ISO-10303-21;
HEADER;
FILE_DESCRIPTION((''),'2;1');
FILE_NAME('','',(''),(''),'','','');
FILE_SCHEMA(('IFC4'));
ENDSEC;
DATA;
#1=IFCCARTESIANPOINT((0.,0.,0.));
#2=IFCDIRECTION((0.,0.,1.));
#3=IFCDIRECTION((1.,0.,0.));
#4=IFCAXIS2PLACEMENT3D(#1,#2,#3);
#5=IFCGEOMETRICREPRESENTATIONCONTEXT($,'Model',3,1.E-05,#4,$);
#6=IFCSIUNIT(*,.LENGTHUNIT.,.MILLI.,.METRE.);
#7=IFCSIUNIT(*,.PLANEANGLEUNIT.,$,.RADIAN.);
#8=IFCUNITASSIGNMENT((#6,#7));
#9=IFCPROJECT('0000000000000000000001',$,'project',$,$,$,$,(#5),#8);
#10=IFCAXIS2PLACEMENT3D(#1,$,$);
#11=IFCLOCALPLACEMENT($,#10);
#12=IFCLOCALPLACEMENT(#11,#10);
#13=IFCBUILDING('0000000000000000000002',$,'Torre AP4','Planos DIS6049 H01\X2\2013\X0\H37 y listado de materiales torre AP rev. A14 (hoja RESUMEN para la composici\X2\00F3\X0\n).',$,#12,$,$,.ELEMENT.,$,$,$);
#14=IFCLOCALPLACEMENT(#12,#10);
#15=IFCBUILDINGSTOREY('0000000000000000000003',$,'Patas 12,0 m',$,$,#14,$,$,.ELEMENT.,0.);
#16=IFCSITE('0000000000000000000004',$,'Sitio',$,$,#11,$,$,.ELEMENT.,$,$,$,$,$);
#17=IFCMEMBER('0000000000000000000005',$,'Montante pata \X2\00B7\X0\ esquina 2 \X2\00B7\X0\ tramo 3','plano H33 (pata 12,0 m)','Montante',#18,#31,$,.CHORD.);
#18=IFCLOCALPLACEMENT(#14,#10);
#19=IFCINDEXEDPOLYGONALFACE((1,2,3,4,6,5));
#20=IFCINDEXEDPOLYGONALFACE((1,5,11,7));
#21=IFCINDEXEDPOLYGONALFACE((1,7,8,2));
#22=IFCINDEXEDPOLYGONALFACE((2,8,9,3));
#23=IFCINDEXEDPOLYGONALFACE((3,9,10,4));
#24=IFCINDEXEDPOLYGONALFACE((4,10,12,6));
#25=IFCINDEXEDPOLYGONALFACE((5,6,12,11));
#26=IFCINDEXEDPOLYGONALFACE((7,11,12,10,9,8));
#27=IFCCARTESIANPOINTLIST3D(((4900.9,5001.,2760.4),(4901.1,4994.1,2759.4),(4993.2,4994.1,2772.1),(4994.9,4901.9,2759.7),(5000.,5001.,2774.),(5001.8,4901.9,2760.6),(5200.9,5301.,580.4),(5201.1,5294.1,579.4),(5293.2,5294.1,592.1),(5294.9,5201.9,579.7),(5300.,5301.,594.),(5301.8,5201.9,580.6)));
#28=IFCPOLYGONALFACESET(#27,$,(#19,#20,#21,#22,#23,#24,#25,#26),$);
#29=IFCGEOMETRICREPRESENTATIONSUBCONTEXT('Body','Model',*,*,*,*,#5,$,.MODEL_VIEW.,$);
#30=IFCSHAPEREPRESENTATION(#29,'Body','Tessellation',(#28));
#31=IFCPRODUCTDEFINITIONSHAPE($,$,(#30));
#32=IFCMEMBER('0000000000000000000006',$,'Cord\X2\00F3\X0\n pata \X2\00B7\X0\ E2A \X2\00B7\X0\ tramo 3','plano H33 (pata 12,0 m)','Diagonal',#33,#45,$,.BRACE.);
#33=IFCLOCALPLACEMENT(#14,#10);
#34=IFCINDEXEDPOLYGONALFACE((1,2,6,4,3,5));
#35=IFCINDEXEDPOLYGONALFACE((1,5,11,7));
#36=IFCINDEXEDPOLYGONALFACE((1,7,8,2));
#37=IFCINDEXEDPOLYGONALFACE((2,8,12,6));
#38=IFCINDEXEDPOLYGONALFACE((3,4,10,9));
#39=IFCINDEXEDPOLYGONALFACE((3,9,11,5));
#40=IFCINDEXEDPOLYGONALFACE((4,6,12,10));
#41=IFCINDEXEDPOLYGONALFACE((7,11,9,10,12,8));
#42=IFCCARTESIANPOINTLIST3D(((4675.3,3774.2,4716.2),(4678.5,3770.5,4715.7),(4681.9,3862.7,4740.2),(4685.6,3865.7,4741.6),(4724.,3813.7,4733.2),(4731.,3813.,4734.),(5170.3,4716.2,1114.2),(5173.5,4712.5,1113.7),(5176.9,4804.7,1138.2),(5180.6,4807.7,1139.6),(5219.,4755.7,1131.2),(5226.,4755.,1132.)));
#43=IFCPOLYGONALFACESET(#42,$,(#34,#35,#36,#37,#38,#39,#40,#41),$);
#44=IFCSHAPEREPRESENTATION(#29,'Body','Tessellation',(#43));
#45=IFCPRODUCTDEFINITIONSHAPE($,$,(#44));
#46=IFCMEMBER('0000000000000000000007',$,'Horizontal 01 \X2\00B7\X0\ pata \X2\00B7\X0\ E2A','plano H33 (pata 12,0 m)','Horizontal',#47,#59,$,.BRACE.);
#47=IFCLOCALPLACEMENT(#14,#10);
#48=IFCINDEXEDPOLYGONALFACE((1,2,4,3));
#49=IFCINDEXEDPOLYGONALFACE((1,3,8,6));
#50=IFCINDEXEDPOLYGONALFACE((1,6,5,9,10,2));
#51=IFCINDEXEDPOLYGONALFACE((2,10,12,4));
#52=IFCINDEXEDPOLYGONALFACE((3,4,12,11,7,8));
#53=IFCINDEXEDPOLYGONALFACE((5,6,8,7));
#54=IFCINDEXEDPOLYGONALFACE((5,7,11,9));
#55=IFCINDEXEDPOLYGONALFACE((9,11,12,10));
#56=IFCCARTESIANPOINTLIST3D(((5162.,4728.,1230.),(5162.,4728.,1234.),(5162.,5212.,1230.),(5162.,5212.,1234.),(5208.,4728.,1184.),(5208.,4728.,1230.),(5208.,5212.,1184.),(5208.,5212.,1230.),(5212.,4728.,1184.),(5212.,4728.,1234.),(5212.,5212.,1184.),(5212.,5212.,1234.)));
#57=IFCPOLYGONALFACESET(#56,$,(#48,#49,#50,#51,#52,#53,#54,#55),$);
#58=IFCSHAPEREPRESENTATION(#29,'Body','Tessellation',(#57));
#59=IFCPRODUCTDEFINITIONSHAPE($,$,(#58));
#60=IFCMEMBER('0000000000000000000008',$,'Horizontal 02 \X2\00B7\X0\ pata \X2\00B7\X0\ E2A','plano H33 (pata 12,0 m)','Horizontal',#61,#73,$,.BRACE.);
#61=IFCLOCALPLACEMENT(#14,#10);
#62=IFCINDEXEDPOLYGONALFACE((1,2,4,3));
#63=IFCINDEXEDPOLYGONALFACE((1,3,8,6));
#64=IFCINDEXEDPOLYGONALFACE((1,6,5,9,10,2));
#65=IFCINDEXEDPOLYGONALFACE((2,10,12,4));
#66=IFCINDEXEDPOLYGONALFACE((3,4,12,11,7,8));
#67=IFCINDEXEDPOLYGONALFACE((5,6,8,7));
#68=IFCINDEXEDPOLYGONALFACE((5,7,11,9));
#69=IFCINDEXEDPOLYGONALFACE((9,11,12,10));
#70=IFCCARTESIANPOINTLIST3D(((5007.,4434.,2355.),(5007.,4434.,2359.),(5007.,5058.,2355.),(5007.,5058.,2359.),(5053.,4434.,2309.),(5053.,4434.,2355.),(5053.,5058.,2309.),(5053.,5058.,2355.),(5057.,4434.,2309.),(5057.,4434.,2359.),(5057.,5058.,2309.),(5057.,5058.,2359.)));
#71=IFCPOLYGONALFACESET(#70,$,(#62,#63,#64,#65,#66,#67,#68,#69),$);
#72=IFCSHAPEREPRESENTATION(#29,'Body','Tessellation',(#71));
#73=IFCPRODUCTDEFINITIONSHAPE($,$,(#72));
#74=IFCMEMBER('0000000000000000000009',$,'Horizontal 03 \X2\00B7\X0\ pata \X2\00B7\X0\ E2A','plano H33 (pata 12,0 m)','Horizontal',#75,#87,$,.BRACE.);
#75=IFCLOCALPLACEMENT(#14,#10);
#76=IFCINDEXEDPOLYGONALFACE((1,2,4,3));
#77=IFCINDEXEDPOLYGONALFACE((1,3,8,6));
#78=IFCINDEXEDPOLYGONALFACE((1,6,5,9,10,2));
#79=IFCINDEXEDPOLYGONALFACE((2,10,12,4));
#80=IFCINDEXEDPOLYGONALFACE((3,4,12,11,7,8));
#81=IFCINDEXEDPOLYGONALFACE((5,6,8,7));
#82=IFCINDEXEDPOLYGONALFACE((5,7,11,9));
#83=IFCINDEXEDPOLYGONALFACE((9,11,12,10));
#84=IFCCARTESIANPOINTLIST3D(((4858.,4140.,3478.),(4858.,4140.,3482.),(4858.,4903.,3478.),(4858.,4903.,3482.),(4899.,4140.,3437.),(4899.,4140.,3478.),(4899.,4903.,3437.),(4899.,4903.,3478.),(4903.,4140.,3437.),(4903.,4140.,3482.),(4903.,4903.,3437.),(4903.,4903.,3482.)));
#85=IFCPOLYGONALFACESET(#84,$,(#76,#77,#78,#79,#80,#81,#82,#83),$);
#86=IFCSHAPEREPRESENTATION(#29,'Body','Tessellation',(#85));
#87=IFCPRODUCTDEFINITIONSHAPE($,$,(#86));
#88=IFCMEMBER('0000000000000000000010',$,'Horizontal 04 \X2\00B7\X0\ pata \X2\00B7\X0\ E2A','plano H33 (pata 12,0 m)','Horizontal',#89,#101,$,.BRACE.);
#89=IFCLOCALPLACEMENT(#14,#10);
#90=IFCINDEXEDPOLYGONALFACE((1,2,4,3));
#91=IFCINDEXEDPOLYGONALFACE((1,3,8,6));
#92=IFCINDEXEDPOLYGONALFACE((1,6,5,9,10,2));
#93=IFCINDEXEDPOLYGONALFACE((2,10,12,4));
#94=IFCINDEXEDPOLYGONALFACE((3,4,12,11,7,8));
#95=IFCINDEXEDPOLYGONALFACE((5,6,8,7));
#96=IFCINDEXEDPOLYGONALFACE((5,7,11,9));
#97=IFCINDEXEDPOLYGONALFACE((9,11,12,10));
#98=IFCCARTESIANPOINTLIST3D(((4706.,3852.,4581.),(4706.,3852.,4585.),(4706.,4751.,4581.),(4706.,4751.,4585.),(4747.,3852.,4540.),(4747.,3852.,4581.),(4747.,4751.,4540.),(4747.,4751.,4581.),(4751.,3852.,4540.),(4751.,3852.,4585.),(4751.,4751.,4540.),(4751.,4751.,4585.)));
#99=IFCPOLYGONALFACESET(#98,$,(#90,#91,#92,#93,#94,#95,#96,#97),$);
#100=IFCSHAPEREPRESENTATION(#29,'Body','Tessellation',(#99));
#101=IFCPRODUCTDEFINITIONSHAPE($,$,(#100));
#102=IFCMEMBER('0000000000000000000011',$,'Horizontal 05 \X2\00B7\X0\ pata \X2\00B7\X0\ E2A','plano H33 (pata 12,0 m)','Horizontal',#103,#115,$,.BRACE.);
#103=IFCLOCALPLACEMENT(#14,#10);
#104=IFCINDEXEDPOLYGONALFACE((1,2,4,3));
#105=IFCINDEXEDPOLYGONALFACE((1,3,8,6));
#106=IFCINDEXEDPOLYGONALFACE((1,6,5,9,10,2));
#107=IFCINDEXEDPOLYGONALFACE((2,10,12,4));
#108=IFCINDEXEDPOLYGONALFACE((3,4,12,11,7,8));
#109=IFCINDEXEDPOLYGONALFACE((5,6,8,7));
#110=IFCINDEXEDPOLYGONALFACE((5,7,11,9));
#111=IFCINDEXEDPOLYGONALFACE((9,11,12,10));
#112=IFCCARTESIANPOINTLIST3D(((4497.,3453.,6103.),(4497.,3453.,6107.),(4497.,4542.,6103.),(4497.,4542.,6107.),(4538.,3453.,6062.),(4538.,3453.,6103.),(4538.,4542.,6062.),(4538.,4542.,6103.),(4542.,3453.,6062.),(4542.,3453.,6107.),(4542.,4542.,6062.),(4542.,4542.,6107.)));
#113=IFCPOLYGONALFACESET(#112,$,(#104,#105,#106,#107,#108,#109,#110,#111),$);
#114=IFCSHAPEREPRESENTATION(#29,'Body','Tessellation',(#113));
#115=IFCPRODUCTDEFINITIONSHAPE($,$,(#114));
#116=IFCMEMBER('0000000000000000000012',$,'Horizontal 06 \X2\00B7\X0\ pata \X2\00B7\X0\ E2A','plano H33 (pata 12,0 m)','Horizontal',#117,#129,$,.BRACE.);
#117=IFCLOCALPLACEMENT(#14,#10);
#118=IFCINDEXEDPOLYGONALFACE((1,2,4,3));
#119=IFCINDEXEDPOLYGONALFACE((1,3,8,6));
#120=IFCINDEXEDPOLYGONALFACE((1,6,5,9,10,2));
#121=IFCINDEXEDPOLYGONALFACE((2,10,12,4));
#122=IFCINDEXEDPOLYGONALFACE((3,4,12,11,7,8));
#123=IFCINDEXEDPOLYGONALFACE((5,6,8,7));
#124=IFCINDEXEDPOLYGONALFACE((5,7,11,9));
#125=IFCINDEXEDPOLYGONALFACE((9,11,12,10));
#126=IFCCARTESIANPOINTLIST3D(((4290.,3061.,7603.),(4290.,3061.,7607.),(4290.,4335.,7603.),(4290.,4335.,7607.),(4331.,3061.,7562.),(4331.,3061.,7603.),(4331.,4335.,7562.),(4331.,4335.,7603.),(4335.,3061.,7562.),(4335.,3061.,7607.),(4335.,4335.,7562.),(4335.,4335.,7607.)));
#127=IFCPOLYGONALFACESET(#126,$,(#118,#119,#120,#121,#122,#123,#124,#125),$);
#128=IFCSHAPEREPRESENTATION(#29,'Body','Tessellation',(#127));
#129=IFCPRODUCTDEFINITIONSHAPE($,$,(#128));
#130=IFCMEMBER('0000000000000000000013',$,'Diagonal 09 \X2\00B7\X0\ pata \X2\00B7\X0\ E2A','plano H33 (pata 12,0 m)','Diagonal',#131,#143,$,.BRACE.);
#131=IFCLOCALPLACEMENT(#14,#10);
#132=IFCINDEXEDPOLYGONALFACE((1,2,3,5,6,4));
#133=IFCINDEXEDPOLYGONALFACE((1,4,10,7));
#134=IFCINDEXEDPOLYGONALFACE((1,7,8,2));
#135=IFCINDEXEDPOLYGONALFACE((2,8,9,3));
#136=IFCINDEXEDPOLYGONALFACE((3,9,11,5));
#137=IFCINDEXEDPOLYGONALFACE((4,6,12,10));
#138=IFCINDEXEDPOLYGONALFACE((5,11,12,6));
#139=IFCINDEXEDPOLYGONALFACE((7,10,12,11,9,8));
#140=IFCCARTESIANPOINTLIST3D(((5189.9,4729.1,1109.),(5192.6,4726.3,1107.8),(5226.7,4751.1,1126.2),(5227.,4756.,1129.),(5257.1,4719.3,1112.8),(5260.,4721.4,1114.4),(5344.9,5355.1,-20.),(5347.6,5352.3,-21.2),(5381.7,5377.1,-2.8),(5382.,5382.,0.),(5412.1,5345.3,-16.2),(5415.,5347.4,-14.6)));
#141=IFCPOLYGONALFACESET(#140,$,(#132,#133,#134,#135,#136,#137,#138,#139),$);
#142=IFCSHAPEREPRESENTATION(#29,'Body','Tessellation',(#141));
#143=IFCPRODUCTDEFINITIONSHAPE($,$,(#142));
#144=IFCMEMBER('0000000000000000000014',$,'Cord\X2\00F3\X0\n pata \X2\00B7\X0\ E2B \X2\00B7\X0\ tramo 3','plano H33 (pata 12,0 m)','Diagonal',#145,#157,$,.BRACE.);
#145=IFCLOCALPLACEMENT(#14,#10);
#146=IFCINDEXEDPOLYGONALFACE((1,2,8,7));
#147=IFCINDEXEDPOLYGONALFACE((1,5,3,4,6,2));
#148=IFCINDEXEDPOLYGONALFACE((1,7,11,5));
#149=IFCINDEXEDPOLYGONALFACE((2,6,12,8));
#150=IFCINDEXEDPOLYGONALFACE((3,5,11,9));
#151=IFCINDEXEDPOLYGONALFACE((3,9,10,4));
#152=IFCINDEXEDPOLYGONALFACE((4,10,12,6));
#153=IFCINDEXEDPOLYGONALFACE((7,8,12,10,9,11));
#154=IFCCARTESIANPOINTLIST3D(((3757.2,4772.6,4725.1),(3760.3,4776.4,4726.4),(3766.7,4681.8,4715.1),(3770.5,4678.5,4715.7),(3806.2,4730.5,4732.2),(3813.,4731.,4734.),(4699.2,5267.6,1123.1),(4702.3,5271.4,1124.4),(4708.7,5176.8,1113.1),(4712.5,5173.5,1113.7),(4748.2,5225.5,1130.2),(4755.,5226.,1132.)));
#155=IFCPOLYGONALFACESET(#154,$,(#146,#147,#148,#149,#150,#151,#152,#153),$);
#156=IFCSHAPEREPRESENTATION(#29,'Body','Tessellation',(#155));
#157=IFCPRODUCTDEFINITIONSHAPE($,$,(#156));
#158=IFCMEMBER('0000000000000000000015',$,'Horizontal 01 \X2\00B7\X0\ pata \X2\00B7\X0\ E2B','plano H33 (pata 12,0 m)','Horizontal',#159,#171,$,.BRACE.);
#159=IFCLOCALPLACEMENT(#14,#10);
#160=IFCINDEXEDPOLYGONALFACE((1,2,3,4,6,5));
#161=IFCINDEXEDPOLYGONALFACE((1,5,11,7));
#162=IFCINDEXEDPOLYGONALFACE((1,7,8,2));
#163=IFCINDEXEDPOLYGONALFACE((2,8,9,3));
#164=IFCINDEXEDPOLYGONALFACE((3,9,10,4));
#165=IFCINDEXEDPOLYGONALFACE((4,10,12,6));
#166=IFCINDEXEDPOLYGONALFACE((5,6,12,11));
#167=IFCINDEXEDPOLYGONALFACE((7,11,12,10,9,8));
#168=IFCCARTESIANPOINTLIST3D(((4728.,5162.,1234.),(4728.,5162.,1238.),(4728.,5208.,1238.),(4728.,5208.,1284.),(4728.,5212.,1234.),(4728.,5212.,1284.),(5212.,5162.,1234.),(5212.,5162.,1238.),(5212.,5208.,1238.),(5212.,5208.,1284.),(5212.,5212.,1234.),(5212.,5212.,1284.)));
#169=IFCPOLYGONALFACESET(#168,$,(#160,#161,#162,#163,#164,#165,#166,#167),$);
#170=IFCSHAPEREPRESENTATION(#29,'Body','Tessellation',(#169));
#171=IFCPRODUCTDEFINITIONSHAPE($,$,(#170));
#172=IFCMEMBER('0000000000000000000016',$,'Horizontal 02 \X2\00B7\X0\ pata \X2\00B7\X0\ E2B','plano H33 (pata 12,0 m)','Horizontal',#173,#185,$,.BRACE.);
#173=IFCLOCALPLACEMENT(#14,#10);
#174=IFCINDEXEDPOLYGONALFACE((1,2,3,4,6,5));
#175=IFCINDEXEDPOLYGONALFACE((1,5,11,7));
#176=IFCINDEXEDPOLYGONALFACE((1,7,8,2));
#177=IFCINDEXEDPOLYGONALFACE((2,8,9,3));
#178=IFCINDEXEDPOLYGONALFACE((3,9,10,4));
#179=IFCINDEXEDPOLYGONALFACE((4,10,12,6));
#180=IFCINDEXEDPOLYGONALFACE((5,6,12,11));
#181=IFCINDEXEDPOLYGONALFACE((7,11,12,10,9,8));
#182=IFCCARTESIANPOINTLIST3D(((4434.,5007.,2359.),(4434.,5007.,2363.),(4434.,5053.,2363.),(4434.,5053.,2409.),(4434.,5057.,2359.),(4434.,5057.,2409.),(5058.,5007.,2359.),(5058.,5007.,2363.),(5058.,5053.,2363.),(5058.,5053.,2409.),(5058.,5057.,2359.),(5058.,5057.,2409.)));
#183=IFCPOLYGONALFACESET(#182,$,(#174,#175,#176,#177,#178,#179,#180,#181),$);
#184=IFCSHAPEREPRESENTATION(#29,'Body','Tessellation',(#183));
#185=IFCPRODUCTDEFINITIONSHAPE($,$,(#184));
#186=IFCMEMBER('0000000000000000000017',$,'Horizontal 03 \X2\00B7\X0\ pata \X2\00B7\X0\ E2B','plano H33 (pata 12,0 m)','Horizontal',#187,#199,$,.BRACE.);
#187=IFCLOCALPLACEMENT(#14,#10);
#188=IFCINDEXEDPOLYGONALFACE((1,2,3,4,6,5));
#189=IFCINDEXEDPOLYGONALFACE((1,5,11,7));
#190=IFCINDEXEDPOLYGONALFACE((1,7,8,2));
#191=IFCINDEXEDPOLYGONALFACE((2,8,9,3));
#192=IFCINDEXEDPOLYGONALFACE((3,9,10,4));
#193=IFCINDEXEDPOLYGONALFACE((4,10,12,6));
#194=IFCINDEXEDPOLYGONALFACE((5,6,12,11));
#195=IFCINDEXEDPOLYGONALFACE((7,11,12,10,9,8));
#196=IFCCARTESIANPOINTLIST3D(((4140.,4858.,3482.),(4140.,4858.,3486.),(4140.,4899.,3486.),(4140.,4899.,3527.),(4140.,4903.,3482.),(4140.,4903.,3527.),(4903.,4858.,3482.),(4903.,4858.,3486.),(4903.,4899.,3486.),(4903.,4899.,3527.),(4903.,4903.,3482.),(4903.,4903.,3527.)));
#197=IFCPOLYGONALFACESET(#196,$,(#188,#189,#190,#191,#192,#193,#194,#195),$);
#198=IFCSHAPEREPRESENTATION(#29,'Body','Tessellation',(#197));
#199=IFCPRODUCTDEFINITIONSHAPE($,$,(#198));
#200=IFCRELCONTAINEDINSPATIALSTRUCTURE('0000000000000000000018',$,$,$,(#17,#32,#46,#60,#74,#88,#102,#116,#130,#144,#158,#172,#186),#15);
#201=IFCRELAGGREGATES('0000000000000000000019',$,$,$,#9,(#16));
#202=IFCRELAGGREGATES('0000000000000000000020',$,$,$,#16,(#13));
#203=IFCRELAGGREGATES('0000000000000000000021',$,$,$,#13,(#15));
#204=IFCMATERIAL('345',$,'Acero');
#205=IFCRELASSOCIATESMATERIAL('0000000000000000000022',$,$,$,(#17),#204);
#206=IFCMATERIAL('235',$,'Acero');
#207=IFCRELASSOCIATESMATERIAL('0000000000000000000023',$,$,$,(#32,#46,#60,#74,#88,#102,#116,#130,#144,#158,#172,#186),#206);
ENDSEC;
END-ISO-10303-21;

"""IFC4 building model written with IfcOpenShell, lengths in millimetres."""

from ifc_helpers import new_model, si_unit, frame, frame_2d, origin, origin_with_axes, place, context, subcontext, project, spatial, l_section, extrude, material, element, save


model = new_model("IFC4")

# Units and contexts
model_context = context("Model", 3, precision=1e-05, world=origin_with_axes())
body_context = subcontext(model_context, "Body", "Model", "MODEL_VIEW")
ifc_project = project(units=[si_unit("LENGTHUNIT", "METRE", prefix="MILLI"), si_unit("PLANEANGLEUNIT", "RADIAN")], contexts=[model_context])

# Site, building, storey
site_placement = place(None, origin())
site = spatial("IfcSite", under=ifc_project, at=site_placement, Name="Sitio", CompositionType="ELEMENT")
building_placement = place(site_placement, origin())
building = spatial("IfcBuilding", under=site, at=building_placement, Name="Torre AP4", Description="Planos DIS6049 H01–H37 y listado de materiales torre AP rev. A14 (hoja RESUMEN para la composición).", CompositionType="ELEMENT")
storey_placement = place(building_placement, origin())
storey = spatial("IfcBuildingStorey", under=building, at=storey_placement, Name="Patas 12,0 m", CompositionType="ELEMENT", Elevation=0.0)

# Members
ifc_material_1 = material(Name="345", Category="Acero")
member_1_placement = place(storey_placement, frame((5000.0, 5001.0, 2774.0), z_axis=(0.13508, 0.13508, -0.981584), x_axis=(0.018415, -0.990835, -0.133819)))
element("IfcMember", 1, at=member_1_placement, inside=storey, material=ifc_material_1, Name="Montante pata · esquina 2 · tramo 3", Description="plano H33 (pata 12,0 m)", ObjectType="Montante", PredefinedType="CHORD", context=body_context, shape_type="SweptSolid", body=[
    extrude(l_section(Depth=100.0, Width=100.0, Thickness=7.0, at=frame_2d((50.0, 50.0))), None, (0.0, 0.0, 1.0), 2220.9),
])
ifc_material_2 = material(Name="235", Category="Acero")
member_2_placement = place(storey_placement, frame((4731.0, 3813.0, 4734.0), z_axis=(0.131793, 0.250805, -0.959024), x_axis=(-0.749767, -0.607646, -0.261948)))
element("IfcMember", 2, at=member_2_placement, inside=storey, material=ifc_material_2, Name="Cordón pata · E2A · tramo 3", Description="plano H33 (pata 12,0 m)", ObjectType="Diagonal", PredefinedType="BRACE", context=body_context, shape_type="SweptSolid", body=[
    extrude(l_section(Depth=70.0, Width=70.0, Thickness=5.0, at=frame_2d((35.0, 35.0))), None, (0.0, 0.0, 1.0), 3755.9),
])
member_3_placement = place(storey_placement, frame((5212.0, 5212.0, 1234.0), z_axis=(0.0, -1.0, 0.0), x_axis=(-1.0, 0.0, 0.0)))
element("IfcMember", 3, at=member_3_placement, inside=storey, material=ifc_material_2, Name="Horizontal 01 · pata · E2A", Description="plano H33 (pata 12,0 m)", ObjectType="Horizontal", PredefinedType="BRACE", context=body_context, shape_type="SweptSolid", body=[
    extrude(l_section(Depth=50.0, Width=50.0, Thickness=4.0, at=frame_2d((25.0, 25.0))), None, (0.0, 0.0, 1.0), 484.0),
])
member_4_placement = place(storey_placement, frame((5057.0, 5058.0, 2359.0), z_axis=(0.0, -1.0, 0.0), x_axis=(-1.0, 0.0, 0.0)))
element("IfcMember", 4, at=member_4_placement, inside=storey, material=ifc_material_2, Name="Horizontal 02 · pata · E2A", Description="plano H33 (pata 12,0 m)", ObjectType="Horizontal", PredefinedType="BRACE", context=body_context, shape_type="SweptSolid", body=[
    extrude(l_section(Depth=50.0, Width=50.0, Thickness=4.0, at=frame_2d((25.0, 25.0))), None, (0.0, 0.0, 1.0), 624.0),
])
member_5_placement = place(storey_placement, frame((4903.0, 4903.0, 3482.0), z_axis=(0.0, -1.0, 0.0), x_axis=(-1.0, 0.0, 0.0)))
element("IfcMember", 5, at=member_5_placement, inside=storey, material=ifc_material_2, Name="Horizontal 03 · pata · E2A", Description="plano H33 (pata 12,0 m)", ObjectType="Horizontal", PredefinedType="BRACE", context=body_context, shape_type="SweptSolid", body=[
    extrude(l_section(Depth=45.0, Width=45.0, Thickness=4.0, at=frame_2d((22.5, 22.5))), None, (0.0, 0.0, 1.0), 763.0),
])
member_6_placement = place(storey_placement, frame((4751.0, 4751.0, 4585.0), z_axis=(0.0, -1.0, 0.0), x_axis=(-1.0, 0.0, 0.0)))
element("IfcMember", 6, at=member_6_placement, inside=storey, material=ifc_material_2, Name="Horizontal 04 · pata · E2A", Description="plano H33 (pata 12,0 m)", ObjectType="Horizontal", PredefinedType="BRACE", context=body_context, shape_type="SweptSolid", body=[
    extrude(l_section(Depth=45.0, Width=45.0, Thickness=4.0, at=frame_2d((22.5, 22.5))), None, (0.0, 0.0, 1.0), 899.0),
])
member_7_placement = place(storey_placement, frame((4542.0, 4542.0, 6107.0), z_axis=(0.0, -1.0, 0.0), x_axis=(-1.0, 0.0, 0.0)))
element("IfcMember", 7, at=member_7_placement, inside=storey, material=ifc_material_2, Name="Horizontal 05 · pata · E2A", Description="plano H33 (pata 12,0 m)", ObjectType="Horizontal", PredefinedType="BRACE", context=body_context, shape_type="SweptSolid", body=[
    extrude(l_section(Depth=45.0, Width=45.0, Thickness=4.0, at=frame_2d((22.5, 22.5))), None, (0.0, 0.0, 1.0), 1089.0),
])
member_8_placement = place(storey_placement, frame((4335.0, 4335.0, 7607.0), z_axis=(0.0, -1.0, 0.0), x_axis=(-1.0, 0.0, 0.0)))
element("IfcMember", 8, at=member_8_placement, inside=storey, material=ifc_material_2, Name="Horizontal 06 · pata · E2A", Description="plano H33 (pata 12,0 m)", ObjectType="Horizontal", PredefinedType="BRACE", context=body_context, shape_type="SweptSolid", body=[
    extrude(l_section(Depth=45.0, Width=45.0, Thickness=4.0, at=frame_2d((22.5, 22.5))), None, (0.0, 0.0, 1.0), 1274.0),
])
member_9_placement = place(storey_placement, frame((5382.0, 5382.0, 0.0), z_axis=(-0.119212, -0.481461, 0.868322), x_axis=(-0.741182, -0.53876, -0.400484)))
element("IfcMember", 9, at=member_9_placement, inside=storey, material=ifc_material_2, Name="Diagonal 09 · pata · E2A", Description="plano H33 (pata 12,0 m)", ObjectType="Diagonal", PredefinedType="BRACE", context=body_context, shape_type="SweptSolid", body=[
    extrude(l_section(Depth=50.0, Width=50.0, Thickness=4.0, at=frame_2d((25.0, 25.0))), None, (0.0, 0.0, 1.0), 1300.2),
])
member_10_placement = place(storey_placement, frame((3813.0, 4731.0, 4734.0), z_axis=(0.250805, 0.131793, -0.959024), x_axis=(-0.607646, -0.749767, -0.261948)))
element("IfcMember", 10, at=member_10_placement, inside=storey, material=ifc_material_2, Name="Cordón pata · E2B · tramo 3", Description="plano H33 (pata 12,0 m)", ObjectType="Diagonal", PredefinedType="BRACE", context=body_context, shape_type="SweptSolid", body=[
    extrude(l_section(Depth=70.0, Width=70.0, Thickness=5.0, at=frame_2d((35.0, 35.0))), None, (0.0, 0.0, 1.0), 3755.9),
])
member_11_placement = place(storey_placement, frame((5212.0, 5212.0, 1234.0), z_axis=(-1.0, 0.0, 0.0), x_axis=(0.0, -1.0, 0.0)))
element("IfcMember", 11, at=member_11_placement, inside=storey, material=ifc_material_2, Name="Horizontal 01 · pata · E2B", Description="plano H33 (pata 12,0 m)", ObjectType="Horizontal", PredefinedType="BRACE", context=body_context, shape_type="SweptSolid", body=[
    extrude(l_section(Depth=50.0, Width=50.0, Thickness=4.0, at=frame_2d((25.0, 25.0))), None, (0.0, 0.0, 1.0), 484.0),
])
member_12_placement = place(storey_placement, frame((5058.0, 5057.0, 2359.0), z_axis=(-1.0, 0.0, 0.0), x_axis=(0.0, -1.0, 0.0)))
element("IfcMember", 12, at=member_12_placement, inside=storey, material=ifc_material_2, Name="Horizontal 02 · pata · E2B", Description="plano H33 (pata 12,0 m)", ObjectType="Horizontal", PredefinedType="BRACE", context=body_context, shape_type="SweptSolid", body=[
    extrude(l_section(Depth=50.0, Width=50.0, Thickness=4.0, at=frame_2d((25.0, 25.0))), None, (0.0, 0.0, 1.0), 624.0),
])
member_13_placement = place(storey_placement, frame((4903.0, 4903.0, 3482.0), z_axis=(-1.0, 0.0, 0.0), x_axis=(0.0, -1.0, 0.0)))
element("IfcMember", 13, at=member_13_placement, inside=storey, material=ifc_material_2, Name="Horizontal 03 · pata · E2B", Description="plano H33 (pata 12,0 m)", ObjectType="Horizontal", PredefinedType="BRACE", context=body_context, shape_type="SweptSolid", body=[
    extrude(l_section(Depth=45.0, Width=45.0, Thickness=4.0, at=frame_2d((22.5, 22.5))), None, (0.0, 0.0, 1.0), 763.0),
])

save(model, "model.ifc")
